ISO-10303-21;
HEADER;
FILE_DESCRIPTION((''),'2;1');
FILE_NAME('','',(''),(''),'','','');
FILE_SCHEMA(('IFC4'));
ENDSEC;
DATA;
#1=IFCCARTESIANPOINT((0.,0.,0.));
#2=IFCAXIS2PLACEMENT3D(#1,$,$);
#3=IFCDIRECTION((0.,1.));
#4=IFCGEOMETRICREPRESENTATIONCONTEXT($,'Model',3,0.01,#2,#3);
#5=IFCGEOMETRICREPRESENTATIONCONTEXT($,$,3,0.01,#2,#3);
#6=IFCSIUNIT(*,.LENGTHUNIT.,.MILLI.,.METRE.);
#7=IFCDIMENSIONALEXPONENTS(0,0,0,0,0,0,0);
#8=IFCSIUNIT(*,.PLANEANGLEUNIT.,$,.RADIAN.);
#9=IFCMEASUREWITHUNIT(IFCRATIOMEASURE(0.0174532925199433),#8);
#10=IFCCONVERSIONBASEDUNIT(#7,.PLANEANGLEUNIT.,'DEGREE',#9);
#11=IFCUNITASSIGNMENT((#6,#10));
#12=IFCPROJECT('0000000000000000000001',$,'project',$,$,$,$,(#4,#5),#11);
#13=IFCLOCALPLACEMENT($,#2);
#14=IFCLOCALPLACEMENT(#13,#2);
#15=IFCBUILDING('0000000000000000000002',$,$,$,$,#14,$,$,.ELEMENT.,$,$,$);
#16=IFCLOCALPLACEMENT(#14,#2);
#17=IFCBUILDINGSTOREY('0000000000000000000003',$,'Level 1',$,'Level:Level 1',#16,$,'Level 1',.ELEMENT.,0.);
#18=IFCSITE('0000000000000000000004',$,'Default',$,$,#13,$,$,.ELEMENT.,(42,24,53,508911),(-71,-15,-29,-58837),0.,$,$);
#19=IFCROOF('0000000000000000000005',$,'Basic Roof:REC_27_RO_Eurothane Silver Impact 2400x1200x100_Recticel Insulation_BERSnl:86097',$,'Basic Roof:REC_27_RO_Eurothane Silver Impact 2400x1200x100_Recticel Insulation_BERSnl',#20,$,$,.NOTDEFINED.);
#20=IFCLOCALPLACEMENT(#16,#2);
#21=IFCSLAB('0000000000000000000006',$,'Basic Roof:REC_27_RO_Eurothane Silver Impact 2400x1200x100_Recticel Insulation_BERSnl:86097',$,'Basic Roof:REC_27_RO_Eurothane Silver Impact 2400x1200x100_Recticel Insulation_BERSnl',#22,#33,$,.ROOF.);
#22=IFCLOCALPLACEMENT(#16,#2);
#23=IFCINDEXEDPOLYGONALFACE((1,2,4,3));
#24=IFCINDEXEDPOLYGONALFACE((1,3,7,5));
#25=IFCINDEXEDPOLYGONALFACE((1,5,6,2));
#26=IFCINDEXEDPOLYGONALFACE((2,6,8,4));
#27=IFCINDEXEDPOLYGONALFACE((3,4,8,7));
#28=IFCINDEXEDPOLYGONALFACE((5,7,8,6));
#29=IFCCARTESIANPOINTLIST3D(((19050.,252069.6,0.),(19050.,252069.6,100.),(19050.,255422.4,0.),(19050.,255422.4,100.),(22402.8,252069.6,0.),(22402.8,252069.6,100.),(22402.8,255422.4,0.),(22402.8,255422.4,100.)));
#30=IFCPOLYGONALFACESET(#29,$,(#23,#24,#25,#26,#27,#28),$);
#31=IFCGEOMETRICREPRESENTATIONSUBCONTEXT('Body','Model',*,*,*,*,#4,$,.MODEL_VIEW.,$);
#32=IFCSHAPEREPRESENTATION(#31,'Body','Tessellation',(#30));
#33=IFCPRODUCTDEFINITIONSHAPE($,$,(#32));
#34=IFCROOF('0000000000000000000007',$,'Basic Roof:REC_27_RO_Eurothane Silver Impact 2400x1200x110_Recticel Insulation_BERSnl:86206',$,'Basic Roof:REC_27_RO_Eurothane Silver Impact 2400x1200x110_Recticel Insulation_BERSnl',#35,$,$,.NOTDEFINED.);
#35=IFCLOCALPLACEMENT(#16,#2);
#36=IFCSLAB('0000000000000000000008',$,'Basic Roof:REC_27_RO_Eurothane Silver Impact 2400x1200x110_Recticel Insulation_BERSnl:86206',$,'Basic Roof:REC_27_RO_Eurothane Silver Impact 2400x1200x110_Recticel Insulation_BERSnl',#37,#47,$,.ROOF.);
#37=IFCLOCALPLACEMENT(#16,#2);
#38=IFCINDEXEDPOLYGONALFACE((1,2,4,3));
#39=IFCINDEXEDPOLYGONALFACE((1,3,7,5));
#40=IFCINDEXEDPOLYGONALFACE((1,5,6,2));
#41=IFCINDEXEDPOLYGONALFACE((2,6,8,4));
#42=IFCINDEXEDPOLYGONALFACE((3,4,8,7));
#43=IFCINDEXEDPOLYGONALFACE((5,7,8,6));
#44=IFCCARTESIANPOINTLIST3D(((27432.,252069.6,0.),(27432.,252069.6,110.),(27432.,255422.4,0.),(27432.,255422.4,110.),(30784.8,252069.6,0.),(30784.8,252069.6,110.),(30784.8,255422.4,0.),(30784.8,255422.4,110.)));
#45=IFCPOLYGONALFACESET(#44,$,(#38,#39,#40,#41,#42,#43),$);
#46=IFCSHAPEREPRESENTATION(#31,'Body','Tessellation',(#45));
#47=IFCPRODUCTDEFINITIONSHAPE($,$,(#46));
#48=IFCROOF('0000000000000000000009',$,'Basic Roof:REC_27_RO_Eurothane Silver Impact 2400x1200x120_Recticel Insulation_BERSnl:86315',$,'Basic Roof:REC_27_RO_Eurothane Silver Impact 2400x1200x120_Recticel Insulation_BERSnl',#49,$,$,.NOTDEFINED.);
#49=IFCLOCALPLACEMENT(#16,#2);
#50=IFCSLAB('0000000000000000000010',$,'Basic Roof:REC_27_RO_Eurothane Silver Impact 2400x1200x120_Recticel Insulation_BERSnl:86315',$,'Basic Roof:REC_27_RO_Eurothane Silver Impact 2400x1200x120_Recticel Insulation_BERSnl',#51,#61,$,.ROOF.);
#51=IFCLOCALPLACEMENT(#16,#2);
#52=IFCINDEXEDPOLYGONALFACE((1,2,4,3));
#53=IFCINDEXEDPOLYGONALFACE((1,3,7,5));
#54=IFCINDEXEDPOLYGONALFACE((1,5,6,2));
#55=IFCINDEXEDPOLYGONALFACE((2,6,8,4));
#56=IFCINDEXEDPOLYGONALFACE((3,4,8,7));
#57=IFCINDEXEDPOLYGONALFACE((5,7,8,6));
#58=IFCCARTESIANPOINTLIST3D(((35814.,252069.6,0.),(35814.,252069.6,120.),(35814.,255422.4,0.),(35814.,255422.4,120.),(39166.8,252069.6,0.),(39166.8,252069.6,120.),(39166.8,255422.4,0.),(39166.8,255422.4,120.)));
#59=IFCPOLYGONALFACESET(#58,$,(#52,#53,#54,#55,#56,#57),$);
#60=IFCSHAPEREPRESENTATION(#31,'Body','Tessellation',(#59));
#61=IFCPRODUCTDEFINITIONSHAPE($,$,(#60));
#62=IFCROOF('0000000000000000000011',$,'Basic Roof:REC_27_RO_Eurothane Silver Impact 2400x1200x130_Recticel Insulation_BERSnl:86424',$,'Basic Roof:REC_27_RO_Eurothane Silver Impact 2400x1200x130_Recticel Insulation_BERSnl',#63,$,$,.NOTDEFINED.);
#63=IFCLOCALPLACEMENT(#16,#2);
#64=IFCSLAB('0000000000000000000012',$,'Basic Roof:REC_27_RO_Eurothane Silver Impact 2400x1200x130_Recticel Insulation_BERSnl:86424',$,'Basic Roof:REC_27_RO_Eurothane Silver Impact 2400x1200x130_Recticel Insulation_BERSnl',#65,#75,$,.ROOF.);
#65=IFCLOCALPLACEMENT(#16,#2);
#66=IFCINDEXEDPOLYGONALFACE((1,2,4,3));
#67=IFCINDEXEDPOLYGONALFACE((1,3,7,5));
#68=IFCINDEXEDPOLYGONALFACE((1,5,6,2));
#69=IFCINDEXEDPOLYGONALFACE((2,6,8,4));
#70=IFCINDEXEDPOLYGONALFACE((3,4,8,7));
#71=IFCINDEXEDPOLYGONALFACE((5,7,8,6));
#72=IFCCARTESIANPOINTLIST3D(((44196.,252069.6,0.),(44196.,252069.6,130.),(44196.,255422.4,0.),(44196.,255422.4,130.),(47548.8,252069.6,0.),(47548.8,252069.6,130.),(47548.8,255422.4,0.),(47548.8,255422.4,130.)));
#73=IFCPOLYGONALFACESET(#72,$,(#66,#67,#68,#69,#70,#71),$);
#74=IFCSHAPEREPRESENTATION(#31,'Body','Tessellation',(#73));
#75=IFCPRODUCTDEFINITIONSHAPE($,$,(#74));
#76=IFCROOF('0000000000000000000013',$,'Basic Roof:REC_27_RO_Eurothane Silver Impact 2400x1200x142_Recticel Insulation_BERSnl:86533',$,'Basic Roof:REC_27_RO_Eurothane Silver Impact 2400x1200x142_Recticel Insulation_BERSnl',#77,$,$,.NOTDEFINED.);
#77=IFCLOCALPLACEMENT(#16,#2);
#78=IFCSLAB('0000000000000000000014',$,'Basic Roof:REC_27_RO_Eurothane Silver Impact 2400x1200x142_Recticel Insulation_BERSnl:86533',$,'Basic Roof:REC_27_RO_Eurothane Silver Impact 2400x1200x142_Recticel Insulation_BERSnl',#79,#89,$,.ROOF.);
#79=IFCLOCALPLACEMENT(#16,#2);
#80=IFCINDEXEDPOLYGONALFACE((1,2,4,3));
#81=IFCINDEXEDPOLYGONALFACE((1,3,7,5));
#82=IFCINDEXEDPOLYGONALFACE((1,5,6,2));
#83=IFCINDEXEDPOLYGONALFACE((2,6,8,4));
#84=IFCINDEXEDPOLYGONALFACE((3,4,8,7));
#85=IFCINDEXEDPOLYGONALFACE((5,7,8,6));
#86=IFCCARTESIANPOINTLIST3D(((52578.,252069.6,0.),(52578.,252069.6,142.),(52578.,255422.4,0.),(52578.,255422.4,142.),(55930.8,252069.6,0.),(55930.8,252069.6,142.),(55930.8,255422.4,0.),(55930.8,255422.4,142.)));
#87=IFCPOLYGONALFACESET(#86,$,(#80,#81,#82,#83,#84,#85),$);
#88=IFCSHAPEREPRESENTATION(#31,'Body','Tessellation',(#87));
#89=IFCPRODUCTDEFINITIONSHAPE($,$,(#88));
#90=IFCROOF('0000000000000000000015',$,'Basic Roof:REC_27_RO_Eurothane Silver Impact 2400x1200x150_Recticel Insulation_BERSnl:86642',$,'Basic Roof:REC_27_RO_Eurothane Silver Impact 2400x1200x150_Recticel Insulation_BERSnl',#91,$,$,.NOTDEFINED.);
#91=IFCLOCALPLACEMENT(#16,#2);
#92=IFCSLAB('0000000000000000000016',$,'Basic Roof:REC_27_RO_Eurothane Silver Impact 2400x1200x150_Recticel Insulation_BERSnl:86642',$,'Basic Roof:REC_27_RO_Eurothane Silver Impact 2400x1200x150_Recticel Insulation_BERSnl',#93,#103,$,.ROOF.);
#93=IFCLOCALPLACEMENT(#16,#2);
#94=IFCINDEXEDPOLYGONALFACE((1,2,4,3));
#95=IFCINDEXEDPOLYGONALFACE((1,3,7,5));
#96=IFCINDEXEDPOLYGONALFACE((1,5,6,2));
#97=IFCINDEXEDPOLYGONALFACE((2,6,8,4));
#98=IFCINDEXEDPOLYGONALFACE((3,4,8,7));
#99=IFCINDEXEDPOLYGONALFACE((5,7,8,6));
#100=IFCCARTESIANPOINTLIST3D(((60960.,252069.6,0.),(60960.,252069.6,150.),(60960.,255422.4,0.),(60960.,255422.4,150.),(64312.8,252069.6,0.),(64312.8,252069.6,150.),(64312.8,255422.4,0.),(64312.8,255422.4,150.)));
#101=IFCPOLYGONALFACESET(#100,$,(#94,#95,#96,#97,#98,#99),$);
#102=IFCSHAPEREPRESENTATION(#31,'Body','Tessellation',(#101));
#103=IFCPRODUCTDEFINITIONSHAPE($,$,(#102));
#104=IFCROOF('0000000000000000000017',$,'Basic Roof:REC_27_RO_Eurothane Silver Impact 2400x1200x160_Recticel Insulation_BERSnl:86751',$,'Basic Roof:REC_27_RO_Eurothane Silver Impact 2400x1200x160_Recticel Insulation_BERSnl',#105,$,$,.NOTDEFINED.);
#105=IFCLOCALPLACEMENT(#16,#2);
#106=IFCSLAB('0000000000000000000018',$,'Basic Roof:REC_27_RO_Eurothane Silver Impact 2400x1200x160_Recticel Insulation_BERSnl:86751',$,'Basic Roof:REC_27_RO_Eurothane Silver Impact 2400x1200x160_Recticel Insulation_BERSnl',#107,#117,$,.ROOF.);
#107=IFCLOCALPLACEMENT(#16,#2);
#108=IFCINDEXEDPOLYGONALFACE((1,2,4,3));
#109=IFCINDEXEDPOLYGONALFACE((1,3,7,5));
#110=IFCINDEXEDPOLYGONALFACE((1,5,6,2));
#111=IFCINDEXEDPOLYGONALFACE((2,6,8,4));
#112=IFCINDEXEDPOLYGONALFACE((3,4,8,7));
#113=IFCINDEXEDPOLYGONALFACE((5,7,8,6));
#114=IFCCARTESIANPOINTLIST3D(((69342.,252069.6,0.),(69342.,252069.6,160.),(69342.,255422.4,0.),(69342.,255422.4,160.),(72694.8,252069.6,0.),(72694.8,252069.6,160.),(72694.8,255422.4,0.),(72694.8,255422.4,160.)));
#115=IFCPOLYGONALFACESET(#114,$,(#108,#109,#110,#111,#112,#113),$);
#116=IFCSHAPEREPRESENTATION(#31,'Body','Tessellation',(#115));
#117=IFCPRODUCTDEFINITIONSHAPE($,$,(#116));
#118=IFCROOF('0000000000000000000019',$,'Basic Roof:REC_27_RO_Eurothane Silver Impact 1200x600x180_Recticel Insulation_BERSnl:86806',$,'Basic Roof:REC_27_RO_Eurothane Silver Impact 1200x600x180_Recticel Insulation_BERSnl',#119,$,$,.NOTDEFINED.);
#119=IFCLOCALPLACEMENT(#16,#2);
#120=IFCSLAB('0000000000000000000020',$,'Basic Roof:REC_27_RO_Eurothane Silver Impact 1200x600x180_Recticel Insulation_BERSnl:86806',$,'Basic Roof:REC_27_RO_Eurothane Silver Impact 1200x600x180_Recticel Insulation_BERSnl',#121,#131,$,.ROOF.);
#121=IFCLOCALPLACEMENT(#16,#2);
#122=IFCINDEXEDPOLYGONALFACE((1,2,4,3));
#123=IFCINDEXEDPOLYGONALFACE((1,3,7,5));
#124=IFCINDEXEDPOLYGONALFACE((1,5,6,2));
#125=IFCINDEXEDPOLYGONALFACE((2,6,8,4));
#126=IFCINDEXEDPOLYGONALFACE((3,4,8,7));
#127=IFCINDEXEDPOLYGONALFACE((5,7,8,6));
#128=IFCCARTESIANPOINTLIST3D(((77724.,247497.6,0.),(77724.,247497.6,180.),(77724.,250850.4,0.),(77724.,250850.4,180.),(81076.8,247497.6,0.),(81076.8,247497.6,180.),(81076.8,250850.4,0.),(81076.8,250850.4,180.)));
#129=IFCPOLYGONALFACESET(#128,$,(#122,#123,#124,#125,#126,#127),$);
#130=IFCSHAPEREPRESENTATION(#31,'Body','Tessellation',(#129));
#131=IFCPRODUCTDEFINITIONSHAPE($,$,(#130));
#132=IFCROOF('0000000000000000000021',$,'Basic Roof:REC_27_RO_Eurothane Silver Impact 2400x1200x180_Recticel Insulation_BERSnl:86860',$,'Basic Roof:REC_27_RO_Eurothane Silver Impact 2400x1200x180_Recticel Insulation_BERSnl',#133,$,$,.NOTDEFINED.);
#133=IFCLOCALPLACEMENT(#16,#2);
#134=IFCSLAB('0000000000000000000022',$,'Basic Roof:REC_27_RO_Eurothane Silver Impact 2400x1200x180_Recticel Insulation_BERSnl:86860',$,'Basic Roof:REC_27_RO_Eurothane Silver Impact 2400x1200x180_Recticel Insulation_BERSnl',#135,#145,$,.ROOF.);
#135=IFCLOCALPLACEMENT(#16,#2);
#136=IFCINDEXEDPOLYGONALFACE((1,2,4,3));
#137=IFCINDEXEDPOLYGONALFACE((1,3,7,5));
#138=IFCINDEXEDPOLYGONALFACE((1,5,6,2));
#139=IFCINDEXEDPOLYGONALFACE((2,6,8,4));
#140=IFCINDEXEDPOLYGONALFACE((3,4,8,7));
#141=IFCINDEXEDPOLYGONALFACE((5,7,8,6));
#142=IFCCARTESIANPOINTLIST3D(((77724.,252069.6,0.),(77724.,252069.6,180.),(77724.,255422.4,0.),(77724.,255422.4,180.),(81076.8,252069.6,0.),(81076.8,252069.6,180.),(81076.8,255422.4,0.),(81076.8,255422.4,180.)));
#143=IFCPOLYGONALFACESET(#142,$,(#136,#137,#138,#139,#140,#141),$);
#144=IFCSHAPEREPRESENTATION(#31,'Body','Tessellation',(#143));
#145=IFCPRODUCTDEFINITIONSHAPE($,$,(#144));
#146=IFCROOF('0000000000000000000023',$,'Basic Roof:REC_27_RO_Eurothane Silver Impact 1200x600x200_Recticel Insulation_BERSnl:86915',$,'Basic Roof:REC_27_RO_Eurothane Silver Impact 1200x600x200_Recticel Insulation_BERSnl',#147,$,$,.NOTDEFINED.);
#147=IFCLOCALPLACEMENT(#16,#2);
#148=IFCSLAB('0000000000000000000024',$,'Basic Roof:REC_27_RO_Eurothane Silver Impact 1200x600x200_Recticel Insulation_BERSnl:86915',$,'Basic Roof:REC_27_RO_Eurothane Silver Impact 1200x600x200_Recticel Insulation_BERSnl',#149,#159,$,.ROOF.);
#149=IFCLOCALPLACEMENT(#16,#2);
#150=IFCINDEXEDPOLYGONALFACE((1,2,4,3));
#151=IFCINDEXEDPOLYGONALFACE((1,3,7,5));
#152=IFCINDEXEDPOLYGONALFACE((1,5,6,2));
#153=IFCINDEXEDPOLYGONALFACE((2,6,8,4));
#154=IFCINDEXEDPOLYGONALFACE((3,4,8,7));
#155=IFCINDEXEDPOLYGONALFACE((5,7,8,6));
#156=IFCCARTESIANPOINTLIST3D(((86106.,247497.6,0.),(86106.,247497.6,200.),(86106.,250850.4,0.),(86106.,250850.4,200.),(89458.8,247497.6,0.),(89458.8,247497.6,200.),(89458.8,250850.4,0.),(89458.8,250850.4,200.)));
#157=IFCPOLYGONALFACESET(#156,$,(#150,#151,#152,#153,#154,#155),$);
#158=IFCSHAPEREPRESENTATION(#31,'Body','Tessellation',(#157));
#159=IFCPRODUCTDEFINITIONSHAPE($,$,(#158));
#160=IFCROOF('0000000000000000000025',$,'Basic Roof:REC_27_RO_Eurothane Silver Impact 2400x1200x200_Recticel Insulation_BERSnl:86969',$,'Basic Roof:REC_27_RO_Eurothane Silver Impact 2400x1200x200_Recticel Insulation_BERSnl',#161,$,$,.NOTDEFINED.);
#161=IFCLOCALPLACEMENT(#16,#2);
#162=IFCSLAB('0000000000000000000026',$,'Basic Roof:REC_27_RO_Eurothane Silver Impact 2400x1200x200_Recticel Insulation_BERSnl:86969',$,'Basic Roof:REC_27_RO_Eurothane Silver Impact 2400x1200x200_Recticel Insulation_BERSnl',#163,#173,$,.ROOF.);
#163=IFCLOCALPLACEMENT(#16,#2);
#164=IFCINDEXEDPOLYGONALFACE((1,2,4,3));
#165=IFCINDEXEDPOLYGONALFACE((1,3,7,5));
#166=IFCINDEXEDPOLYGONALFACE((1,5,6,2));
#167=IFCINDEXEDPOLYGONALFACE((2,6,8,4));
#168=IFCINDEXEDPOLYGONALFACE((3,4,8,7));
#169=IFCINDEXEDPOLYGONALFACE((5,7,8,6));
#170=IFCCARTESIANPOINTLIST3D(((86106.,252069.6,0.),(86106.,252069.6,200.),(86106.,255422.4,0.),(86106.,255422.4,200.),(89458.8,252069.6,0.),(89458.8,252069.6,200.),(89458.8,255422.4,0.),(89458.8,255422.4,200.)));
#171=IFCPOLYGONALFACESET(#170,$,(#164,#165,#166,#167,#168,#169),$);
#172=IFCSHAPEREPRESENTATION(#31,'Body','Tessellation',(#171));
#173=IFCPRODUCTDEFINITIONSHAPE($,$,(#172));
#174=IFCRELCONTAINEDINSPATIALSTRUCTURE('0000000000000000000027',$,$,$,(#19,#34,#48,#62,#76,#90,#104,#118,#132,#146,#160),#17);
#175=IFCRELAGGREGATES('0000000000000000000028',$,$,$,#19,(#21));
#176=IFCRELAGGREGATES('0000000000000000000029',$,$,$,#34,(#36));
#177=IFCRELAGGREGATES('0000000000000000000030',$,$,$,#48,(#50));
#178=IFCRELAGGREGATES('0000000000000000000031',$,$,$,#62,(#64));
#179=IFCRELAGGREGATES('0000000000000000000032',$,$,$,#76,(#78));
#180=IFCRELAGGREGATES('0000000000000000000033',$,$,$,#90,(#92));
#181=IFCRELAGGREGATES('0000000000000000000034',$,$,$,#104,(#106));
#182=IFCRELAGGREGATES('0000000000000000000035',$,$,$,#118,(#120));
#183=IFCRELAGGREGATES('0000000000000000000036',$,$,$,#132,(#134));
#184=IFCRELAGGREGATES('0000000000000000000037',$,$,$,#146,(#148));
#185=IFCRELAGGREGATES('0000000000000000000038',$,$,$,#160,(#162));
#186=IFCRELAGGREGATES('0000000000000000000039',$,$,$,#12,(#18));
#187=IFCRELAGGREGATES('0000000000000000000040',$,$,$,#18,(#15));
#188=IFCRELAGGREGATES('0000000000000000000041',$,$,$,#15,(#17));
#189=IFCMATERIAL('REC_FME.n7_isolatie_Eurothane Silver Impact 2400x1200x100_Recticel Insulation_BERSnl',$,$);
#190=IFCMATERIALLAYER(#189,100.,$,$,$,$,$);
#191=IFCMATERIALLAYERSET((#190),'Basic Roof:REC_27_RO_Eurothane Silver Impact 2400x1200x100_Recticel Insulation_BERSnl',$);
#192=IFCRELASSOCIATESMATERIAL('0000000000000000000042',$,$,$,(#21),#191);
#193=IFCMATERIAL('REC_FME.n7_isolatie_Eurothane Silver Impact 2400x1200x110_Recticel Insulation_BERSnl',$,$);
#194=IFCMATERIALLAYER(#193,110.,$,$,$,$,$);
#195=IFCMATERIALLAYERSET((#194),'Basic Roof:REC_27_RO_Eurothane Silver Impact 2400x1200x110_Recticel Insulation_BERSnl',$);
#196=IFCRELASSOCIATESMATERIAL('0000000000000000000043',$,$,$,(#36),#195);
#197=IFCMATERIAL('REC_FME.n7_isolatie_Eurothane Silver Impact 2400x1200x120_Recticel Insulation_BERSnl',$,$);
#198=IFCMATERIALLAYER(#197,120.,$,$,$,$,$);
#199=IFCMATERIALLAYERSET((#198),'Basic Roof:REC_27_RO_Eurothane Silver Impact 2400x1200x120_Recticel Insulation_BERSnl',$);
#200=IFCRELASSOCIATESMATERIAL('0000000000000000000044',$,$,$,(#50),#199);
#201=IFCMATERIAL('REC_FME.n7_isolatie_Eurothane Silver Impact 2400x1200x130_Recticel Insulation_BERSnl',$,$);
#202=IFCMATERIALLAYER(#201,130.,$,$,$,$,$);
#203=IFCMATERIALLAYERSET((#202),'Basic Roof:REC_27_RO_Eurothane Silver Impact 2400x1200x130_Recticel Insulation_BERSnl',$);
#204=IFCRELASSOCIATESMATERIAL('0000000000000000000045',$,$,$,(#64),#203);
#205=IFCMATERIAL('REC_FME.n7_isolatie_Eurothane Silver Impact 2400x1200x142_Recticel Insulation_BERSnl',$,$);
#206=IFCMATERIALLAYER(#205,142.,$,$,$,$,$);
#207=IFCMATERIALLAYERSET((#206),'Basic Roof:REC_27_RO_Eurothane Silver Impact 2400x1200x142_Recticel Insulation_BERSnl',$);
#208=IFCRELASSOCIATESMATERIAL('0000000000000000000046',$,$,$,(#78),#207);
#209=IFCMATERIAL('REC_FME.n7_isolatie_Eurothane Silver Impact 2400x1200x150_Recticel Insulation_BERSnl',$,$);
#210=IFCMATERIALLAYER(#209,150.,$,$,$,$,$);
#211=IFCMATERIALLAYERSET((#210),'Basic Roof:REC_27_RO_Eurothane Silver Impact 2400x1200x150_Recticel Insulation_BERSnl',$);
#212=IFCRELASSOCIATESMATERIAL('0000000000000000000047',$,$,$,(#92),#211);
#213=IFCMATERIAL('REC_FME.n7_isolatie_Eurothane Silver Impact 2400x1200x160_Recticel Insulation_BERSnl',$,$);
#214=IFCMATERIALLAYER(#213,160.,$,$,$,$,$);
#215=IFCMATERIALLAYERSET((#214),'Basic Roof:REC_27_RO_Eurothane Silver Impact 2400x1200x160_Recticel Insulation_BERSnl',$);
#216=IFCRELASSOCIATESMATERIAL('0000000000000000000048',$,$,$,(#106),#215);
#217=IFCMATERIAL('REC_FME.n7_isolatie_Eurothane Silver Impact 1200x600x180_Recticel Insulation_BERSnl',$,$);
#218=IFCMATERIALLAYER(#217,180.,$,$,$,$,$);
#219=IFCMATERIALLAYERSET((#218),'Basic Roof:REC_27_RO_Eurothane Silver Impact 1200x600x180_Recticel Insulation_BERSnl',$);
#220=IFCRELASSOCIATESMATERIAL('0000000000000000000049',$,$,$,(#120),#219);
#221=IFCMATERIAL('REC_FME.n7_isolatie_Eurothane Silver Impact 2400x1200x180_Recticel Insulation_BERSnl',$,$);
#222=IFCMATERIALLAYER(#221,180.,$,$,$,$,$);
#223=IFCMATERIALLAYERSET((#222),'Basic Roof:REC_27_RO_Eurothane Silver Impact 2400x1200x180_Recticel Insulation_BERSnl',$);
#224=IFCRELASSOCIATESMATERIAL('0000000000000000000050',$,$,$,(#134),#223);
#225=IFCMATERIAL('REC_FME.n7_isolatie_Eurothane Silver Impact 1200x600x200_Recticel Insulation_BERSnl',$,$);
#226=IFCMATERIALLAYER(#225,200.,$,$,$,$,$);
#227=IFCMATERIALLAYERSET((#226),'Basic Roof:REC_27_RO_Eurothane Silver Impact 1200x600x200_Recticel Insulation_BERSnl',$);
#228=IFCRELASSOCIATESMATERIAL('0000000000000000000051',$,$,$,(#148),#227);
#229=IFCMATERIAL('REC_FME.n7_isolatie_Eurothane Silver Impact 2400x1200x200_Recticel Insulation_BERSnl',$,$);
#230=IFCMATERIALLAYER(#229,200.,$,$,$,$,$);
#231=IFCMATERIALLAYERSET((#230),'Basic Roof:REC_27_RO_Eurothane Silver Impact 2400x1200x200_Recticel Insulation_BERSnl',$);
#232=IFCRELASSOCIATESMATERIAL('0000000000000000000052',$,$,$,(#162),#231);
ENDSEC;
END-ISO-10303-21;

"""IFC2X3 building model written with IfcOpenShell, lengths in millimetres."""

from ifc_helpers import new_model, entity, si_unit, converted_unit, direction, frame, frame_2d, origin, place, context, subcontext, project, spatial, rectangle, extrude, material, layer, layer_set, element, aggregate, save


model = new_model("IFC2X3")

# Units and contexts
model_context = context("Model", 3, precision=0.01, world=origin(), true_north=direction((0.0, 1.0)))
context_of_model = context(None, 3, precision=0.01, world=origin(), true_north=direction((0.0, 1.0)))
body_context = subcontext(model_context, "Body", "Model", "MODEL_VIEW")
ifc_project = project(units=[si_unit("LENGTHUNIT", "METRE", prefix="MILLI"), converted_unit("PLANEANGLEUNIT", "DEGREE", entity("IfcRatioMeasure", 0.0174532925199433), si_unit("PLANEANGLEUNIT", "RADIAN"), dimensions=[0, 0, 0, 0, 0, 0, 0])], contexts=[model_context, context_of_model])

# Site, building, storey
site_placement = place(None, origin())
site = spatial("IfcSite", under=ifc_project, at=site_placement, Name="Default", CompositionType="ELEMENT", RefLatitude=(42, 24, 53, 508911), RefLongitude=(-71, -15, -29, -58837), RefElevation=0.0)
building_placement = place(site_placement, origin())
building = spatial("IfcBuilding", under=site, at=building_placement, CompositionType="ELEMENT")
storey_placement = place(building_placement, origin())
storey = spatial("IfcBuildingStorey", under=building, at=storey_placement, Name="Level 1", ObjectType="Level:Level 1", LongName="Level 1", CompositionType="ELEMENT", Elevation=0.0)

# Roofs, slabs
roof_1_placement = place(storey_placement, frame((19050.0, 252069.6, 0.0)))
roof_1 = element("IfcRoof", 1, at=roof_1_placement, inside=storey, Name="Basic Roof:REC_27_RO_Eurothane Silver Impact 2400x1200x100_Recticel Insulation_BERSnl:86097", ObjectType="Basic Roof:REC_27_RO_Eurothane Silver Impact 2400x1200x100_Recticel Insulation_BERSnl", ShapeType="NOTDEFINED")
ifc_material_1 = material(Name="REC_FME.n7_isolatie_Eurothane Silver Impact 2400x1200x100_Recticel Insulation_BERSnl")
ifc_layer_1 = layer(ifc_material_1, 100.0)
ifc_layer_set_1 = layer_set([ifc_layer_1], Name="Basic Roof:REC_27_RO_Eurothane Silver Impact 2400x1200x100_Recticel Insulation_BERSnl")
slab_1_placement = place(roof_1_placement, origin())
slab_1 = element("IfcSlab", 2, at=slab_1_placement, material=ifc_layer_set_1, Name="Basic Roof:REC_27_RO_Eurothane Silver Impact 2400x1200x100_Recticel Insulation_BERSnl:86097", ObjectType="Basic Roof:REC_27_RO_Eurothane Silver Impact 2400x1200x100_Recticel Insulation_BERSnl", PredefinedType="ROOF", context=body_context, shape_type="SweptSolid", body=[
    extrude(rectangle(XDim=3352.8, YDim=3352.8, at=frame_2d((0.0, 0.0), x_axis=(-1.0, 0.0))), frame((1676.4, 1676.4, 0.0)), (0.0, 0.0, 1.0), 100.0),
])
aggregate(roof_1, [slab_1])
roof_2_placement = place(storey_placement, frame((27432.0, 252069.6, 0.0)))
roof_2 = element("IfcRoof", 3, at=roof_2_placement, inside=storey, Name="Basic Roof:REC_27_RO_Eurothane Silver Impact 2400x1200x110_Recticel Insulation_BERSnl:86206", ObjectType="Basic Roof:REC_27_RO_Eurothane Silver Impact 2400x1200x110_Recticel Insulation_BERSnl", ShapeType="NOTDEFINED")
ifc_material_2 = material(Name="REC_FME.n7_isolatie_Eurothane Silver Impact 2400x1200x110_Recticel Insulation_BERSnl")
ifc_layer_2 = layer(ifc_material_2, 110.0)
ifc_layer_set_2 = layer_set([ifc_layer_2], Name="Basic Roof:REC_27_RO_Eurothane Silver Impact 2400x1200x110_Recticel Insulation_BERSnl")
slab_2_placement = place(roof_2_placement, origin())
slab_2 = element("IfcSlab", 4, at=slab_2_placement, material=ifc_layer_set_2, Name="Basic Roof:REC_27_RO_Eurothane Silver Impact 2400x1200x110_Recticel Insulation_BERSnl:86206", ObjectType="Basic Roof:REC_27_RO_Eurothane Silver Impact 2400x1200x110_Recticel Insulation_BERSnl", PredefinedType="ROOF", context=body_context, shape_type="SweptSolid", body=[
    extrude(rectangle(XDim=3352.8, YDim=3352.8, at=frame_2d((0.0, 0.0), x_axis=(-1.0, 0.0))), frame((1676.4, 1676.4, 0.0)), (0.0, 0.0, 1.0), 110.0),
])
aggregate(roof_2, [slab_2])
roof_3_placement = place(storey_placement, frame((35814.0, 252069.6, 0.0)))
roof_3 = element("IfcRoof", 5, at=roof_3_placement, inside=storey, Name="Basic Roof:REC_27_RO_Eurothane Silver Impact 2400x1200x120_Recticel Insulation_BERSnl:86315", ObjectType="Basic Roof:REC_27_RO_Eurothane Silver Impact 2400x1200x120_Recticel Insulation_BERSnl", ShapeType="NOTDEFINED")
ifc_material_3 = material(Name="REC_FME.n7_isolatie_Eurothane Silver Impact 2400x1200x120_Recticel Insulation_BERSnl")
ifc_layer_3 = layer(ifc_material_3, 120.0)
ifc_layer_set_3 = layer_set([ifc_layer_3], Name="Basic Roof:REC_27_RO_Eurothane Silver Impact 2400x1200x120_Recticel Insulation_BERSnl")
slab_3_placement = place(roof_3_placement, origin())
slab_3 = element("IfcSlab", 6, at=slab_3_placement, material=ifc_layer_set_3, Name="Basic Roof:REC_27_RO_Eurothane Silver Impact 2400x1200x120_Recticel Insulation_BERSnl:86315", ObjectType="Basic Roof:REC_27_RO_Eurothane Silver Impact 2400x1200x120_Recticel Insulation_BERSnl", PredefinedType="ROOF", context=body_context, shape_type="SweptSolid", body=[
    extrude(rectangle(XDim=3352.8, YDim=3352.8, at=frame_2d((0.0, 0.0), x_axis=(-1.0, 0.0))), frame((1676.4, 1676.4, 0.0)), (0.0, 0.0, 1.0), 120.0),
])
aggregate(roof_3, [slab_3])
roof_4_placement = place(storey_placement, frame((44196.0, 252069.6, 0.0)))
roof_4 = element("IfcRoof", 7, at=roof_4_placement, inside=storey, Name="Basic Roof:REC_27_RO_Eurothane Silver Impact 2400x1200x130_Recticel Insulation_BERSnl:86424", ObjectType="Basic Roof:REC_27_RO_Eurothane Silver Impact 2400x1200x130_Recticel Insulation_BERSnl", ShapeType="NOTDEFINED")
ifc_material_4 = material(Name="REC_FME.n7_isolatie_Eurothane Silver Impact 2400x1200x130_Recticel Insulation_BERSnl")
ifc_layer_4 = layer(ifc_material_4, 130.0)
ifc_layer_set_4 = layer_set([ifc_layer_4], Name="Basic Roof:REC_27_RO_Eurothane Silver Impact 2400x1200x130_Recticel Insulation_BERSnl")
slab_4_placement = place(roof_4_placement, origin())
slab_4 = element("IfcSlab", 8, at=slab_4_placement, material=ifc_layer_set_4, Name="Basic Roof:REC_27_RO_Eurothane Silver Impact 2400x1200x130_Recticel Insulation_BERSnl:86424", ObjectType="Basic Roof:REC_27_RO_Eurothane Silver Impact 2400x1200x130_Recticel Insulation_BERSnl", PredefinedType="ROOF", context=body_context, shape_type="SweptSolid", body=[
    extrude(rectangle(XDim=3352.8, YDim=3352.8, at=frame_2d((0.0, 0.0), x_axis=(-1.0, 0.0))), frame((1676.4, 1676.4, 0.0)), (0.0, 0.0, 1.0), 130.0),
])
aggregate(roof_4, [slab_4])
roof_5_placement = place(storey_placement, frame((52578.0, 252069.6, 0.0)))
roof_5 = element("IfcRoof", 9, at=roof_5_placement, inside=storey, Name="Basic Roof:REC_27_RO_Eurothane Silver Impact 2400x1200x142_Recticel Insulation_BERSnl:86533", ObjectType="Basic Roof:REC_27_RO_Eurothane Silver Impact 2400x1200x142_Recticel Insulation_BERSnl", ShapeType="NOTDEFINED")
ifc_material_5 = material(Name="REC_FME.n7_isolatie_Eurothane Silver Impact 2400x1200x142_Recticel Insulation_BERSnl")
ifc_layer_5 = layer(ifc_material_5, 142.0)
ifc_layer_set_5 = layer_set([ifc_layer_5], Name="Basic Roof:REC_27_RO_Eurothane Silver Impact 2400x1200x142_Recticel Insulation_BERSnl")
slab_5_placement = place(roof_5_placement, origin())
slab_5 = element("IfcSlab", 10, at=slab_5_placement, material=ifc_layer_set_5, Name="Basic Roof:REC_27_RO_Eurothane Silver Impact 2400x1200x142_Recticel Insulation_BERSnl:86533", ObjectType="Basic Roof:REC_27_RO_Eurothane Silver Impact 2400x1200x142_Recticel Insulation_BERSnl", PredefinedType="ROOF", context=body_context, shape_type="SweptSolid", body=[
    extrude(rectangle(XDim=3352.8, YDim=3352.8, at=frame_2d((0.0, 0.0), x_axis=(-1.0, 0.0))), frame((1676.4, 1676.4, 0.0)), (0.0, 0.0, 1.0), 142.0),
])
aggregate(roof_5, [slab_5])
roof_6_placement = place(storey_placement, frame((60960.0, 252069.6, 0.0)))
roof_6 = element("IfcRoof", 11, at=roof_6_placement, inside=storey, Name="Basic Roof:REC_27_RO_Eurothane Silver Impact 2400x1200x150_Recticel Insulation_BERSnl:86642", ObjectType="Basic Roof:REC_27_RO_Eurothane Silver Impact 2400x1200x150_Recticel Insulation_BERSnl", ShapeType="NOTDEFINED")
ifc_material_6 = material(Name="REC_FME.n7_isolatie_Eurothane Silver Impact 2400x1200x150_Recticel Insulation_BERSnl")
ifc_layer_6 = layer(ifc_material_6, 150.0)
ifc_layer_set_6 = layer_set([ifc_layer_6], Name="Basic Roof:REC_27_RO_Eurothane Silver Impact 2400x1200x150_Recticel Insulation_BERSnl")
slab_6_placement = place(roof_6_placement, origin())
slab_6 = element("IfcSlab", 12, at=slab_6_placement, material=ifc_layer_set_6, Name="Basic Roof:REC_27_RO_Eurothane Silver Impact 2400x1200x150_Recticel Insulation_BERSnl:86642", ObjectType="Basic Roof:REC_27_RO_Eurothane Silver Impact 2400x1200x150_Recticel Insulation_BERSnl", PredefinedType="ROOF", context=body_context, shape_type="SweptSolid", body=[
    extrude(rectangle(XDim=3352.8, YDim=3352.8, at=frame_2d((0.0, 0.0), x_axis=(-1.0, 0.0))), frame((1676.4, 1676.4, 0.0)), (0.0, 0.0, 1.0), 150.0),
])
aggregate(roof_6, [slab_6])
roof_7_placement = place(storey_placement, frame((69342.0, 252069.6, 0.0)))
roof_7 = element("IfcRoof", 13, at=roof_7_placement, inside=storey, Name="Basic Roof:REC_27_RO_Eurothane Silver Impact 2400x1200x160_Recticel Insulation_BERSnl:86751", ObjectType="Basic Roof:REC_27_RO_Eurothane Silver Impact 2400x1200x160_Recticel Insulation_BERSnl", ShapeType="NOTDEFINED")
ifc_material_7 = material(Name="REC_FME.n7_isolatie_Eurothane Silver Impact 2400x1200x160_Recticel Insulation_BERSnl")
ifc_layer_7 = layer(ifc_material_7, 160.0)
ifc_layer_set_7 = layer_set([ifc_layer_7], Name="Basic Roof:REC_27_RO_Eurothane Silver Impact 2400x1200x160_Recticel Insulation_BERSnl")
slab_7_placement = place(roof_7_placement, origin())
slab_7 = element("IfcSlab", 14, at=slab_7_placement, material=ifc_layer_set_7, Name="Basic Roof:REC_27_RO_Eurothane Silver Impact 2400x1200x160_Recticel Insulation_BERSnl:86751", ObjectType="Basic Roof:REC_27_RO_Eurothane Silver Impact 2400x1200x160_Recticel Insulation_BERSnl", PredefinedType="ROOF", context=body_context, shape_type="SweptSolid", body=[
    extrude(rectangle(XDim=3352.8, YDim=3352.8, at=frame_2d((0.0, 0.0), x_axis=(-1.0, 0.0))), frame((1676.4, 1676.4, 0.0)), (0.0, 0.0, 1.0), 160.0),
])
aggregate(roof_7, [slab_7])
roof_8_placement = place(storey_placement, frame((77724.0, 247497.6, 0.0)))
roof_8 = element("IfcRoof", 15, at=roof_8_placement, inside=storey, Name="Basic Roof:REC_27_RO_Eurothane Silver Impact 1200x600x180_Recticel Insulation_BERSnl:86806", ObjectType="Basic Roof:REC_27_RO_Eurothane Silver Impact 1200x600x180_Recticel Insulation_BERSnl", ShapeType="NOTDEFINED")
ifc_material_8 = material(Name="REC_FME.n7_isolatie_Eurothane Silver Impact 1200x600x180_Recticel Insulation_BERSnl")
ifc_layer_8 = layer(ifc_material_8, 180.0)
ifc_layer_set_8 = layer_set([ifc_layer_8], Name="Basic Roof:REC_27_RO_Eurothane Silver Impact 1200x600x180_Recticel Insulation_BERSnl")
slab_8_placement = place(roof_8_placement, origin())
slab_8 = element("IfcSlab", 16, at=slab_8_placement, material=ifc_layer_set_8, Name="Basic Roof:REC_27_RO_Eurothane Silver Impact 1200x600x180_Recticel Insulation_BERSnl:86806", ObjectType="Basic Roof:REC_27_RO_Eurothane Silver Impact 1200x600x180_Recticel Insulation_BERSnl", PredefinedType="ROOF", context=body_context, shape_type="SweptSolid", body=[
    extrude(rectangle(XDim=3352.8, YDim=3352.8, at=frame_2d((0.0, 0.0), x_axis=(-1.0, 0.0))), frame((1676.4, 1676.4, 0.0)), (0.0, 0.0, 1.0), 180.0),
])
aggregate(roof_8, [slab_8])
roof_9_placement = place(storey_placement, frame((77724.0, 252069.6, 0.0)))
roof_9 = element("IfcRoof", 17, at=roof_9_placement, inside=storey, Name="Basic Roof:REC_27_RO_Eurothane Silver Impact 2400x1200x180_Recticel Insulation_BERSnl:86860", ObjectType="Basic Roof:REC_27_RO_Eurothane Silver Impact 2400x1200x180_Recticel Insulation_BERSnl", ShapeType="NOTDEFINED")
ifc_material_9 = material(Name="REC_FME.n7_isolatie_Eurothane Silver Impact 2400x1200x180_Recticel Insulation_BERSnl")
ifc_layer_9 = layer(ifc_material_9, 180.0)
ifc_layer_set_9 = layer_set([ifc_layer_9], Name="Basic Roof:REC_27_RO_Eurothane Silver Impact 2400x1200x180_Recticel Insulation_BERSnl")
slab_9_placement = place(roof_9_placement, origin())
slab_9 = element("IfcSlab", 18, at=slab_9_placement, material=ifc_layer_set_9, Name="Basic Roof:REC_27_RO_Eurothane Silver Impact 2400x1200x180_Recticel Insulation_BERSnl:86860", ObjectType="Basic Roof:REC_27_RO_Eurothane Silver Impact 2400x1200x180_Recticel Insulation_BERSnl", PredefinedType="ROOF", context=body_context, shape_type="SweptSolid", body=[
    extrude(rectangle(XDim=3352.8, YDim=3352.8, at=frame_2d((0.0, 0.0), x_axis=(-1.0, 0.0))), frame((1676.4, 1676.4, 0.0)), (0.0, 0.0, 1.0), 180.0),
])
aggregate(roof_9, [slab_9])
roof_10_placement = place(storey_placement, frame((86106.0, 247497.6, 0.0)))
roof_10 = element("IfcRoof", 19, at=roof_10_placement, inside=storey, Name="Basic Roof:REC_27_RO_Eurothane Silver Impact 1200x600x200_Recticel Insulation_BERSnl:86915", ObjectType="Basic Roof:REC_27_RO_Eurothane Silver Impact 1200x600x200_Recticel Insulation_BERSnl", ShapeType="NOTDEFINED")
ifc_material_10 = material(Name="REC_FME.n7_isolatie_Eurothane Silver Impact 1200x600x200_Recticel Insulation_BERSnl")
ifc_layer_10 = layer(ifc_material_10, 200.0)
ifc_layer_set_10 = layer_set([ifc_layer_10], Name="Basic Roof:REC_27_RO_Eurothane Silver Impact 1200x600x200_Recticel Insulation_BERSnl")
slab_10_placement = place(roof_10_placement, origin())
slab_10 = element("IfcSlab", 20, at=slab_10_placement, material=ifc_layer_set_10, Name="Basic Roof:REC_27_RO_Eurothane Silver Impact 1200x600x200_Recticel Insulation_BERSnl:86915", ObjectType="Basic Roof:REC_27_RO_Eurothane Silver Impact 1200x600x200_Recticel Insulation_BERSnl", PredefinedType="ROOF", context=body_context, shape_type="SweptSolid", body=[
    extrude(rectangle(XDim=3352.8, YDim=3352.8, at=frame_2d((0.0, 0.0), x_axis=(-1.0, 0.0))), frame((1676.4, 1676.4, 0.0)), (0.0, 0.0, 1.0), 200.0),
])
aggregate(roof_10, [slab_10])
roof_11_placement = place(storey_placement, frame((86106.0, 252069.6, 0.0)))
roof_11 = element("IfcRoof", 21, at=roof_11_placement, inside=storey, Name="Basic Roof:REC_27_RO_Eurothane Silver Impact 2400x1200x200_Recticel Insulation_BERSnl:86969", ObjectType="Basic Roof:REC_27_RO_Eurothane Silver Impact 2400x1200x200_Recticel Insulation_BERSnl", ShapeType="NOTDEFINED")
ifc_material_11 = material(Name="REC_FME.n7_isolatie_Eurothane Silver Impact 2400x1200x200_Recticel Insulation_BERSnl")
ifc_layer_11 = layer(ifc_material_11, 200.0)
ifc_layer_set_11 = layer_set([ifc_layer_11], Name="Basic Roof:REC_27_RO_Eurothane Silver Impact 2400x1200x200_Recticel Insulation_BERSnl")
slab_11_placement = place(roof_11_placement, origin())
slab_11 = element("IfcSlab", 22, at=slab_11_placement, material=ifc_layer_set_11, Name="Basic Roof:REC_27_RO_Eurothane Silver Impact 2400x1200x200_Recticel Insulation_BERSnl:86969", ObjectType="Basic Roof:REC_27_RO_Eurothane Silver Impact 2400x1200x200_Recticel Insulation_BERSnl", PredefinedType="ROOF", context=body_context, shape_type="SweptSolid", body=[
    extrude(rectangle(XDim=3352.8, YDim=3352.8, at=frame_2d((0.0, 0.0), x_axis=(-1.0, 0.0))), frame((1676.4, 1676.4, 0.0)), (0.0, 0.0, 1.0), 200.0),
])
aggregate(roof_11, [slab_11])

save(model, "model.ifc")
